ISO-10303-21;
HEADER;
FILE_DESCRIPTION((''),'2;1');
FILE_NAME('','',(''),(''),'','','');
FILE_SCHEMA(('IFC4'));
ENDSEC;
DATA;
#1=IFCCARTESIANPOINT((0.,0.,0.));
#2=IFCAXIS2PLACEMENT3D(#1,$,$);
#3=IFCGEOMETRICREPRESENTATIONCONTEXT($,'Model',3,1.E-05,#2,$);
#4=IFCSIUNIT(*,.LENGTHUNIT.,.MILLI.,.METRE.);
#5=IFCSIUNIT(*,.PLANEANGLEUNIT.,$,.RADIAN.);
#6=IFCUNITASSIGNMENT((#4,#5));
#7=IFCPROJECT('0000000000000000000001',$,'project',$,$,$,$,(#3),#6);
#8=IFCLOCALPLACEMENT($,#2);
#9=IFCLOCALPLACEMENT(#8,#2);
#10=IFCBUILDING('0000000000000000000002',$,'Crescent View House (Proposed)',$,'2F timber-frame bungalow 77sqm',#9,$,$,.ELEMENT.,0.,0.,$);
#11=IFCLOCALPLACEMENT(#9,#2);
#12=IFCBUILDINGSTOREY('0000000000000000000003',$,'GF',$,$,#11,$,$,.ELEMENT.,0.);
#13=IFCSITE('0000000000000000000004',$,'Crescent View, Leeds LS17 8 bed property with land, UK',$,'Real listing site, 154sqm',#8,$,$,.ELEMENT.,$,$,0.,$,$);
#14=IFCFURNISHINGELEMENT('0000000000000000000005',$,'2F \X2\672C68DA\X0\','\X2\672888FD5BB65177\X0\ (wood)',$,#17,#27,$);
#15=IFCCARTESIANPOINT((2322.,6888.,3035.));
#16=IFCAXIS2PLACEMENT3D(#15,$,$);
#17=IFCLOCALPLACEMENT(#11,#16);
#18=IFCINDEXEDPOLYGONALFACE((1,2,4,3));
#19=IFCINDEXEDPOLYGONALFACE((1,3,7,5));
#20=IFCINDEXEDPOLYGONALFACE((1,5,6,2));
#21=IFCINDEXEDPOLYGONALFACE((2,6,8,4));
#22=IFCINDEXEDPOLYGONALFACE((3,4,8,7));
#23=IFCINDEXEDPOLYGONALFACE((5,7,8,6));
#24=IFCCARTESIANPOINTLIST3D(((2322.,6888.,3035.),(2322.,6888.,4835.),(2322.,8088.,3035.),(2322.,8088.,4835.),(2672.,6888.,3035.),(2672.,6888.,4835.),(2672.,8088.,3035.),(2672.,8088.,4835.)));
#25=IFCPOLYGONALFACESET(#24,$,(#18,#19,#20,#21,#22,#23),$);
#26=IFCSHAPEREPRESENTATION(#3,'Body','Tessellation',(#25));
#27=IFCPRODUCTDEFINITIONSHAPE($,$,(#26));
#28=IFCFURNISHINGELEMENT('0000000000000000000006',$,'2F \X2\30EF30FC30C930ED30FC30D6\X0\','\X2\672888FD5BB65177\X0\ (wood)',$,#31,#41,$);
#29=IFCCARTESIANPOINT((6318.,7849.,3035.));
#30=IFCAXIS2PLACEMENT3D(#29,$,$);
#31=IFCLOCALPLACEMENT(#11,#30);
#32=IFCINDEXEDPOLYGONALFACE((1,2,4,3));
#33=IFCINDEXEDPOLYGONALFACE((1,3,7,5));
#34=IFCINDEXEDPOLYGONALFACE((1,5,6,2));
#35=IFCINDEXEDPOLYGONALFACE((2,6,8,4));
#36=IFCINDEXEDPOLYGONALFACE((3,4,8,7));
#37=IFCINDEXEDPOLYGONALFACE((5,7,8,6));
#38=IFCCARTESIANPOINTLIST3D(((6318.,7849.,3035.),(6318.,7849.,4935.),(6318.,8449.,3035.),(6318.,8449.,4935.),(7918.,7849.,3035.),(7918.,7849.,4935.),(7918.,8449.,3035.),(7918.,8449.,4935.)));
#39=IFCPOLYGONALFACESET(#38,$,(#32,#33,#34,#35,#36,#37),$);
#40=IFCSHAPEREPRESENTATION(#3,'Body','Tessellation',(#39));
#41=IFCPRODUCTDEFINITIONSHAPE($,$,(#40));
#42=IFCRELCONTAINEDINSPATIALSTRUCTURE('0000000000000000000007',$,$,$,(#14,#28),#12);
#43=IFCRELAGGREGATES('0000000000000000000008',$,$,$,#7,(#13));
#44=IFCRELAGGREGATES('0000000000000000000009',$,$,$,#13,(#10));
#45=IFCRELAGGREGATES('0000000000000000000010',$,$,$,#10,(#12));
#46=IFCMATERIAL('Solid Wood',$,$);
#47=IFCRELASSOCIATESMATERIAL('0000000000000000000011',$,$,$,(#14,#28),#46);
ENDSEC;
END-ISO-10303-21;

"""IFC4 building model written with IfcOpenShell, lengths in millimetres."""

from ifc_helpers import new_model, si_unit, frame, frame_2d, origin, place, context, project, spatial, rectangle, extrude, material, element, save


model = new_model("IFC4")

# Units and contexts
model_context = context("Model", 3, precision=1e-05, world=origin())
ifc_project = project(units=[si_unit("LENGTHUNIT", "METRE", prefix="MILLI"), si_unit("PLANEANGLEUNIT", "RADIAN")], contexts=[model_context])

# Site, building, storey
site_placement = place(None, origin())
site = spatial("IfcSite", under=ifc_project, at=site_placement, Name="Crescent View, Leeds LS17 8 bed property with land, UK", ObjectType="Real listing site, 154sqm", CompositionType="ELEMENT", RefElevation=0.0)
building_placement = place(site_placement, origin())
building = spatial("IfcBuilding", under=site, at=building_placement, Name="Crescent View House (Proposed)", ObjectType="2F timber-frame bungalow 77sqm", CompositionType="ELEMENT", ElevationOfRefHeight=0.0, ElevationOfTerrain=0.0)
storey_placement = place(building_placement, origin())
storey = spatial("IfcBuildingStorey", under=building, at=storey_placement, Name="GF", CompositionType="ELEMENT", Elevation=0.0)

# Shared definitions
ifc_material_1 = material(Name="Solid Wood")

# Furnishing elements
furnishing_1_placement = place(storey_placement, frame((2322.0, 6888.0, 3035.0)))
element("IfcFurnishingElement", 1, at=furnishing_1_placement, inside=storey, material=ifc_material_1, Name="2F 本棚", Description="木製家具 (wood)", context=model_context, shape_type="SweptSolid", body=[
    extrude(rectangle(XDim=350.0, YDim=1200.0, at=frame_2d((175.0, 600.0))), frame((2322.0, 6888.0, 3035.0)), (0.0, 0.0, 1.0), 1800.0),
])
furnishing_2_placement = place(storey_placement, frame((6318.0, 7849.0, 3035.0)))
element("IfcFurnishingElement", 2, at=furnishing_2_placement, inside=storey, material=ifc_material_1, Name="2F ワードローブ", Description="木製家具 (wood)", context=model_context, shape_type="SweptSolid", body=[
    extrude(rectangle(XDim=1600.0, YDim=600.0, at=frame_2d((800.0, 300.0))), frame((6318.0, 7849.0, 3035.0)), (0.0, 0.0, 1.0), 1900.0),
])

save(model, "model.ifc")
